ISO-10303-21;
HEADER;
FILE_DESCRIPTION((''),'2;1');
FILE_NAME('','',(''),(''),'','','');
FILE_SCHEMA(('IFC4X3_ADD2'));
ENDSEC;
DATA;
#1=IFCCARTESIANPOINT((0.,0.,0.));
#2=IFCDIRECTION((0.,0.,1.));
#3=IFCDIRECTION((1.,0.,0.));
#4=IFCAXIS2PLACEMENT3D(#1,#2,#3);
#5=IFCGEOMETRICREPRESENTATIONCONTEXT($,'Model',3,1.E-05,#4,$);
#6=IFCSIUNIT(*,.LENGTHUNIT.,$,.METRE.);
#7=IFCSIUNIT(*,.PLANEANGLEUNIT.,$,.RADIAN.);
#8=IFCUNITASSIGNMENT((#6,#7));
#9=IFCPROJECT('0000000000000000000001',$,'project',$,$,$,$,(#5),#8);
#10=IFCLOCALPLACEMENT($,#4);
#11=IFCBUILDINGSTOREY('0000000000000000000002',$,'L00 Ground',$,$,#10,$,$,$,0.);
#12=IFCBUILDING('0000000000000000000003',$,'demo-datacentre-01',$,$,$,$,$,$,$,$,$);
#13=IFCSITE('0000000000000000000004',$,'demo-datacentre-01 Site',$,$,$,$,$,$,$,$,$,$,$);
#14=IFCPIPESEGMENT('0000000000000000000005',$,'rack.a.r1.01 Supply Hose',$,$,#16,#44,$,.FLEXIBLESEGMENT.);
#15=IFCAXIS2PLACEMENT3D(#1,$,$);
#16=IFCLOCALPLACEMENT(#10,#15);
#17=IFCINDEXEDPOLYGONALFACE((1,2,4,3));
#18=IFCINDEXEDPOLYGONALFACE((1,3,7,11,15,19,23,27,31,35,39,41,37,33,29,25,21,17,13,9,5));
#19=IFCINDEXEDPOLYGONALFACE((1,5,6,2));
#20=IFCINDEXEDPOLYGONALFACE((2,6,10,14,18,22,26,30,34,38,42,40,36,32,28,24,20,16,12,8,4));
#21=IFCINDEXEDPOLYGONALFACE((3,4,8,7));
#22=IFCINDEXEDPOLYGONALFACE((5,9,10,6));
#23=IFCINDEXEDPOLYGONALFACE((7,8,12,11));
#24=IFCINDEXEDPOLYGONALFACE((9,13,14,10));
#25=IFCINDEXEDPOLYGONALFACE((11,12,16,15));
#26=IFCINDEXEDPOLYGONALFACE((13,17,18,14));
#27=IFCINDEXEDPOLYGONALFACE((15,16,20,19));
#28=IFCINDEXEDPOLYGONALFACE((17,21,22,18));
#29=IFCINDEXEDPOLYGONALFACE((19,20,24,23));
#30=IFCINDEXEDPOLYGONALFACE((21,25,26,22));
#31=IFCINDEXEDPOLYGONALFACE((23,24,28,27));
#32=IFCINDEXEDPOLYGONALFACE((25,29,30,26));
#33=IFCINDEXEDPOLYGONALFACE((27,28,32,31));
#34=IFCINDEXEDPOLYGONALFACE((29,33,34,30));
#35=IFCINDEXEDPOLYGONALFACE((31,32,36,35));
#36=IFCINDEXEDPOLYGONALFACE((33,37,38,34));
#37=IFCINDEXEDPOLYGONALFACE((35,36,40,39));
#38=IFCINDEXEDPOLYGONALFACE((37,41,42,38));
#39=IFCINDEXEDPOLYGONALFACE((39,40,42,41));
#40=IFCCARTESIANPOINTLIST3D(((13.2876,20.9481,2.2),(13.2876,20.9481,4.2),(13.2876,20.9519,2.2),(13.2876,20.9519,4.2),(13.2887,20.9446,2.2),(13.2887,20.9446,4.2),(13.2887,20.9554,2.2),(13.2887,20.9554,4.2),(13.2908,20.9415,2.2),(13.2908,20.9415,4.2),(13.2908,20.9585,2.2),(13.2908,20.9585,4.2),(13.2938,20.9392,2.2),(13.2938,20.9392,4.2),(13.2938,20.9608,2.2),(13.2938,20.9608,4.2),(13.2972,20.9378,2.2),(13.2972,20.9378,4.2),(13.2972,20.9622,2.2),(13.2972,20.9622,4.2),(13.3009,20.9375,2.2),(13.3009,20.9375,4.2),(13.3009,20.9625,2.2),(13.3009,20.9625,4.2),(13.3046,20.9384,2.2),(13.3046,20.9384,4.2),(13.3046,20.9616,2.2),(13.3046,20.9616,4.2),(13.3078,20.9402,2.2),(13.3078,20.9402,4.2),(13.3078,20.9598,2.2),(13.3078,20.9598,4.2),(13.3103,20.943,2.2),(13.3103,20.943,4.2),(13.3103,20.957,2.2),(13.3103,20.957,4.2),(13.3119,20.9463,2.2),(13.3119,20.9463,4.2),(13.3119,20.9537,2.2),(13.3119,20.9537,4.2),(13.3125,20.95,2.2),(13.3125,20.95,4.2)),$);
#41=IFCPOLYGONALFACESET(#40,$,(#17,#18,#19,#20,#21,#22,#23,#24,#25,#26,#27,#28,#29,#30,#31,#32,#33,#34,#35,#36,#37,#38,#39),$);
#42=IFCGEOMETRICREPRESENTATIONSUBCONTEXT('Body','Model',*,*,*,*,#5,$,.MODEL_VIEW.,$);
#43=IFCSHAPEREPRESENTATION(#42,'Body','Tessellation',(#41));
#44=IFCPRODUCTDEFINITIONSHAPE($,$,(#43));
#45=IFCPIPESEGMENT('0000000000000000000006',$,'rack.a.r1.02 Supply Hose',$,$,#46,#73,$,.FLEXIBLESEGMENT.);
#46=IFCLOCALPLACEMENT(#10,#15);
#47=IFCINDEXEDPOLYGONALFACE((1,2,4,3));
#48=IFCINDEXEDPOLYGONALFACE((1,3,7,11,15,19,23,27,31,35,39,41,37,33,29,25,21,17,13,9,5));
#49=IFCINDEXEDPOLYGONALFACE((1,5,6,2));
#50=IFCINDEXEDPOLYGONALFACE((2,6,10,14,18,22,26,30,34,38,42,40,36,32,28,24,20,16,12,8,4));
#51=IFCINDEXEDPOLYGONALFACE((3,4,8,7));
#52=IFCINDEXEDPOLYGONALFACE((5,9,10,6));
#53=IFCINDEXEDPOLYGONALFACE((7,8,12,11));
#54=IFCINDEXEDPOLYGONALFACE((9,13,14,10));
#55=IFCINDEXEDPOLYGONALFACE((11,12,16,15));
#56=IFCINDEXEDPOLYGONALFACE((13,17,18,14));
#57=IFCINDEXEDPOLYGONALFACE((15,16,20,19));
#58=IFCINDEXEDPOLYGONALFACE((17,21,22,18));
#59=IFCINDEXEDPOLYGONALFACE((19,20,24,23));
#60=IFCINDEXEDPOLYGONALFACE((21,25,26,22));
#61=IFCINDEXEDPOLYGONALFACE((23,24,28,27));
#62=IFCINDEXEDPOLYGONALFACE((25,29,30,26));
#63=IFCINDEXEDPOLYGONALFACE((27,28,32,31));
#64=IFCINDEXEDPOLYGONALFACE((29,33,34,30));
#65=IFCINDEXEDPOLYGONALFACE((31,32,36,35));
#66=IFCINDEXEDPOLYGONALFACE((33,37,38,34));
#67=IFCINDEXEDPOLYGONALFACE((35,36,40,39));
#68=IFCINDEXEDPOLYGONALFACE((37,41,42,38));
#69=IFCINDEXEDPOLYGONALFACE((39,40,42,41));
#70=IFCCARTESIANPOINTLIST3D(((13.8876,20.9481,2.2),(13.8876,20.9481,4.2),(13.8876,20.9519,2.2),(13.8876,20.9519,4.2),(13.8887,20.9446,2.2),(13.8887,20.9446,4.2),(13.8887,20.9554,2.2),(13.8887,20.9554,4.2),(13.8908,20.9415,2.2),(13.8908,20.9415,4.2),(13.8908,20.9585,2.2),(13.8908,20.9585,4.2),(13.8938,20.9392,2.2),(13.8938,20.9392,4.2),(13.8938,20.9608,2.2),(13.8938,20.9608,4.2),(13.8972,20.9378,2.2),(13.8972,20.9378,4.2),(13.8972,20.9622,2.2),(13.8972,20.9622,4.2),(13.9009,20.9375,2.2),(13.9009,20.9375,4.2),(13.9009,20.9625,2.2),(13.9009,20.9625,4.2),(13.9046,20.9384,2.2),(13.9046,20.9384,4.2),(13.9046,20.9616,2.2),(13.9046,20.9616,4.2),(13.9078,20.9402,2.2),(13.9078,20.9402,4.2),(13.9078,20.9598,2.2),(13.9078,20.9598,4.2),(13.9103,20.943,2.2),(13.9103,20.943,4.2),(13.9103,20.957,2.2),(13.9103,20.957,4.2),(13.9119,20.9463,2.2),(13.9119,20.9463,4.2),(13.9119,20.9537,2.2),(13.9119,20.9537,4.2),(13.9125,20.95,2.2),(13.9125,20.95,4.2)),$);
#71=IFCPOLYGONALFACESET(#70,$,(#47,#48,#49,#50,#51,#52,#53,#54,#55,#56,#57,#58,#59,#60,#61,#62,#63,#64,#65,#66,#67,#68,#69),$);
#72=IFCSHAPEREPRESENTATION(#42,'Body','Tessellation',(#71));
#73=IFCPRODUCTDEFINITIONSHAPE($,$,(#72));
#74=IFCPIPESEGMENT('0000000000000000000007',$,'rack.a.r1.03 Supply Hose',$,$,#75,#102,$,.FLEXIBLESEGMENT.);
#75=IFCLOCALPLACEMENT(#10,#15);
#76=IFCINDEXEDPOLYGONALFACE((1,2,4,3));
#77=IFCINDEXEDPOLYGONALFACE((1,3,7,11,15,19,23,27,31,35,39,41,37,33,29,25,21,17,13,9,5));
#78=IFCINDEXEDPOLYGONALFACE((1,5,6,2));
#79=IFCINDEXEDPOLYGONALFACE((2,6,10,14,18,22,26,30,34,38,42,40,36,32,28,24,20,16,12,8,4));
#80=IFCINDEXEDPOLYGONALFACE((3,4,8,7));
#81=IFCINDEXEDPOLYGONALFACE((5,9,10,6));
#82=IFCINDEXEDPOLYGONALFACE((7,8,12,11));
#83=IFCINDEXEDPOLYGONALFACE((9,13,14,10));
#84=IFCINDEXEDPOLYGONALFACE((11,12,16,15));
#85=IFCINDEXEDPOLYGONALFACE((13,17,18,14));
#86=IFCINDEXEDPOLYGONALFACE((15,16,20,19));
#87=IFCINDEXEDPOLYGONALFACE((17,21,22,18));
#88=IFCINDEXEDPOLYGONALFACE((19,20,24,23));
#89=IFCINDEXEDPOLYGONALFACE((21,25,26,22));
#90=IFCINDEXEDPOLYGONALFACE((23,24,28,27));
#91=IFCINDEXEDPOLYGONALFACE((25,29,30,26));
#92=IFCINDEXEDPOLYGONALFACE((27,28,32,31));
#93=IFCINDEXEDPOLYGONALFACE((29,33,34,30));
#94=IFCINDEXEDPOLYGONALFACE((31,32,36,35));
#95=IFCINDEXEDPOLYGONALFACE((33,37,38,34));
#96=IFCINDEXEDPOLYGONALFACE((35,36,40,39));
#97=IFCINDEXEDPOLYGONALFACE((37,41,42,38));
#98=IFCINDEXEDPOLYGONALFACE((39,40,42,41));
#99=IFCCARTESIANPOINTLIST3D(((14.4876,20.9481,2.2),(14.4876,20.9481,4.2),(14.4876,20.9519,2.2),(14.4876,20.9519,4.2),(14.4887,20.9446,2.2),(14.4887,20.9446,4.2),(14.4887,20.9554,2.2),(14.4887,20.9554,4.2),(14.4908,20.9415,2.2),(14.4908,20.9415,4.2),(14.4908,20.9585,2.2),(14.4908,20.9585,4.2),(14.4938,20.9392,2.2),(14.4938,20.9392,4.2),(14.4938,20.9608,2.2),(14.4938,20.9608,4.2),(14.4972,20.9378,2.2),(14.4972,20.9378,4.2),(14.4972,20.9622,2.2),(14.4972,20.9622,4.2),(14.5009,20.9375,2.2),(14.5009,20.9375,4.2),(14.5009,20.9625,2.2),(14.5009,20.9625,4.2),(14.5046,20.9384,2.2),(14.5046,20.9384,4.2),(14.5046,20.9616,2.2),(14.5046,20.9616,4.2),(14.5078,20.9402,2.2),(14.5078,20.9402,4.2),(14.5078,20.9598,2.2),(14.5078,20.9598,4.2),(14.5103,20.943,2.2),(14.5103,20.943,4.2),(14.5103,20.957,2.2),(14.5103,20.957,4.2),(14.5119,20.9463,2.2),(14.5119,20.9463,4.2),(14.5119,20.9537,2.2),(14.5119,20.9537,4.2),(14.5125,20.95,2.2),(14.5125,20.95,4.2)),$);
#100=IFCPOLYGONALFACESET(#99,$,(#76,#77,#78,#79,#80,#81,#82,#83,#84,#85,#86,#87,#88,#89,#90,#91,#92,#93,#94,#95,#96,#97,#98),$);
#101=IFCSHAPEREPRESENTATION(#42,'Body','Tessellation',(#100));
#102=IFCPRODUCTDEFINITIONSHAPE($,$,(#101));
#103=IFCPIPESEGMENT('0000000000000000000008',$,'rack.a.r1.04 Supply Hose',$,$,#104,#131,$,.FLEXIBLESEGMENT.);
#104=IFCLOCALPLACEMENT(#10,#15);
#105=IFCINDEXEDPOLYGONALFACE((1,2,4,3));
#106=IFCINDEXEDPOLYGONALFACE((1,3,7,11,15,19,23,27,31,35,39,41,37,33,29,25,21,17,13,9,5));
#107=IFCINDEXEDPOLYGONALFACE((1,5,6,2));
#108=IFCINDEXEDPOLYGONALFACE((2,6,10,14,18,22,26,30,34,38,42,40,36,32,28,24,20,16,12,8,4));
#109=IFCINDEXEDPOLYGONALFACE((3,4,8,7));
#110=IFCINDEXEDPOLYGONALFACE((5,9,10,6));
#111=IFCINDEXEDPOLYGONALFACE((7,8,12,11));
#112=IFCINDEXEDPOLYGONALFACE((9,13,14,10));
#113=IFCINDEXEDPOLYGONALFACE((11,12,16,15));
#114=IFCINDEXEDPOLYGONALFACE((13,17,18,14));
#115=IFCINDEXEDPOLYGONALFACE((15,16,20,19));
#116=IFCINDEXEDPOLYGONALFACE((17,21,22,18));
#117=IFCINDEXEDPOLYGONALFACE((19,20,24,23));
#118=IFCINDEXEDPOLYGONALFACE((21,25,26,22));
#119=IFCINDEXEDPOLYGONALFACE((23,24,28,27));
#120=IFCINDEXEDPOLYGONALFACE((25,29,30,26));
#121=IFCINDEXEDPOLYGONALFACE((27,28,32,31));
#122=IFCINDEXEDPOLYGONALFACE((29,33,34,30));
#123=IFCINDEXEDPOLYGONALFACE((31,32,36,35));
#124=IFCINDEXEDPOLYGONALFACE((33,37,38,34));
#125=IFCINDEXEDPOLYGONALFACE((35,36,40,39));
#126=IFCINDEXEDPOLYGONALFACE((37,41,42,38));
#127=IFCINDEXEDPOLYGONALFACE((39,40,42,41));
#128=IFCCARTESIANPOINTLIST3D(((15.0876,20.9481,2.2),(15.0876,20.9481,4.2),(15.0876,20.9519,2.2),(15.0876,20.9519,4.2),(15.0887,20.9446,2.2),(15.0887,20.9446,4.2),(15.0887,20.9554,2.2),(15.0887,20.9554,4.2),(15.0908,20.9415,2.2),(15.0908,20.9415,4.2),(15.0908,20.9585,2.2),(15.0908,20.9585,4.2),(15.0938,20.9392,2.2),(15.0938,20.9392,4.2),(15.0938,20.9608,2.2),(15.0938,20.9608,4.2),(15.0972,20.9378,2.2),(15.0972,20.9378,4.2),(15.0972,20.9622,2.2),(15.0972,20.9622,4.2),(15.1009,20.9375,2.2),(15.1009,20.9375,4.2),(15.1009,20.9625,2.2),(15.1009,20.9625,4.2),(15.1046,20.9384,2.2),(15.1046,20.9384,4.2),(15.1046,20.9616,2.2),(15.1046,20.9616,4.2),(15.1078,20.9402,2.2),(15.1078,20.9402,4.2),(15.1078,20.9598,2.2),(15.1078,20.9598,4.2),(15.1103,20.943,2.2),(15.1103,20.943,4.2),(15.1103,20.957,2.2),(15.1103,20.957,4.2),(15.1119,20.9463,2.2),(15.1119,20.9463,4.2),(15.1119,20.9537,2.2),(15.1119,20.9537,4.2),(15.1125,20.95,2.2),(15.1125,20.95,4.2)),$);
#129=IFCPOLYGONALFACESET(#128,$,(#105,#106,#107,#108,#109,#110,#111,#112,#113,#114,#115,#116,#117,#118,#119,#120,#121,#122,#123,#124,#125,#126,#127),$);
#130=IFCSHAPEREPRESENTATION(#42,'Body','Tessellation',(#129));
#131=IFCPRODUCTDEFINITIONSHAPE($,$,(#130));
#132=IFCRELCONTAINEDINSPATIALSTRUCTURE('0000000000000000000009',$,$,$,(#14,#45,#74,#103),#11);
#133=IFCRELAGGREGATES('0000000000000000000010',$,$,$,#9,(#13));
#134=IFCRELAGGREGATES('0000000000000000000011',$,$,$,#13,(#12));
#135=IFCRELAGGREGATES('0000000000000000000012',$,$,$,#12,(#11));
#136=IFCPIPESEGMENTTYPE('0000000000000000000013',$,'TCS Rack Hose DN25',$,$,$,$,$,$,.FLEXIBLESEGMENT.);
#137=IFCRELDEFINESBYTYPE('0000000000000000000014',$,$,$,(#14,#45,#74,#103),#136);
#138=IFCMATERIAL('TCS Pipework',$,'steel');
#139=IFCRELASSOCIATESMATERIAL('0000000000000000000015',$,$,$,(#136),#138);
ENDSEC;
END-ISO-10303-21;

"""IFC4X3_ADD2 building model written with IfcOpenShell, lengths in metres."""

from ifc_helpers import new_model, si_unit, frame, origin_with_axes, place, context, subcontext, project, spatial, circle, extrude, material, type_object, element, save


model = new_model("IFC4X3_ADD2")

# Units and contexts
model_context = context("Model", 3, precision=1e-05, world=origin_with_axes())
body_context = subcontext(model_context, "Body", "Model", "MODEL_VIEW")
ifc_project = project(units=[si_unit("LENGTHUNIT", "METRE"), si_unit("PLANEANGLEUNIT", "RADIAN")], contexts=[model_context])

# Site, building, storey
site = spatial("IfcSite", under=ifc_project, Name="demo-datacentre-01 Site")
building = spatial("IfcBuilding", under=site, Name="demo-datacentre-01")
storey_placement = place(None, origin_with_axes())
storey = spatial("IfcBuildingStorey", under=building, at=storey_placement, Name="L00 Ground", Elevation=0.0)

# Shared definitions
ifc_material_1 = material(Name="TCS Pipework", Category="steel")

# Pipe segments
pipe_segment_type_1 = type_object("IfcPipeSegmentType", Name="TCS Rack Hose DN25", PredefinedType="FLEXIBLESEGMENT", material=ifc_material_1)
for number, where, z_axis, x_axis, name in (
    (1, (13.3, 20.95, 4.2), (0.0, 0.0, -1.0), (1.0, 0.0, 0.0), "rack.a.r1.01 Supply Hose"),
    (2, (13.9, 20.95, 4.2), (0.0, 0.0, -1.0), (1.0, 0.0, 0.0), "rack.a.r1.02 Supply Hose"),
    (3, (14.5, 20.95, 4.2), (0.0, 0.0, -1.0), (1.0, 0.0, 0.0), "rack.a.r1.03 Supply Hose"),
    (4, (15.1, 20.95, 4.2), (0.0, 0.0, -1.0), (1.0, 0.0, 0.0), "rack.a.r1.04 Supply Hose"),
):
    element("IfcPipeSegment", number, at=place(storey_placement, frame(where, z_axis=z_axis, x_axis=x_axis)), inside=storey, type_object=pipe_segment_type_1, Name=name, PredefinedType="FLEXIBLESEGMENT", context=body_context, shape_type="SweptSolid", body=[
        extrude(circle(Radius=0.0125), origin_with_axes(), (0.0, 0.0, 1.0), 2.0),
    ])

save(model, "model.ifc")
